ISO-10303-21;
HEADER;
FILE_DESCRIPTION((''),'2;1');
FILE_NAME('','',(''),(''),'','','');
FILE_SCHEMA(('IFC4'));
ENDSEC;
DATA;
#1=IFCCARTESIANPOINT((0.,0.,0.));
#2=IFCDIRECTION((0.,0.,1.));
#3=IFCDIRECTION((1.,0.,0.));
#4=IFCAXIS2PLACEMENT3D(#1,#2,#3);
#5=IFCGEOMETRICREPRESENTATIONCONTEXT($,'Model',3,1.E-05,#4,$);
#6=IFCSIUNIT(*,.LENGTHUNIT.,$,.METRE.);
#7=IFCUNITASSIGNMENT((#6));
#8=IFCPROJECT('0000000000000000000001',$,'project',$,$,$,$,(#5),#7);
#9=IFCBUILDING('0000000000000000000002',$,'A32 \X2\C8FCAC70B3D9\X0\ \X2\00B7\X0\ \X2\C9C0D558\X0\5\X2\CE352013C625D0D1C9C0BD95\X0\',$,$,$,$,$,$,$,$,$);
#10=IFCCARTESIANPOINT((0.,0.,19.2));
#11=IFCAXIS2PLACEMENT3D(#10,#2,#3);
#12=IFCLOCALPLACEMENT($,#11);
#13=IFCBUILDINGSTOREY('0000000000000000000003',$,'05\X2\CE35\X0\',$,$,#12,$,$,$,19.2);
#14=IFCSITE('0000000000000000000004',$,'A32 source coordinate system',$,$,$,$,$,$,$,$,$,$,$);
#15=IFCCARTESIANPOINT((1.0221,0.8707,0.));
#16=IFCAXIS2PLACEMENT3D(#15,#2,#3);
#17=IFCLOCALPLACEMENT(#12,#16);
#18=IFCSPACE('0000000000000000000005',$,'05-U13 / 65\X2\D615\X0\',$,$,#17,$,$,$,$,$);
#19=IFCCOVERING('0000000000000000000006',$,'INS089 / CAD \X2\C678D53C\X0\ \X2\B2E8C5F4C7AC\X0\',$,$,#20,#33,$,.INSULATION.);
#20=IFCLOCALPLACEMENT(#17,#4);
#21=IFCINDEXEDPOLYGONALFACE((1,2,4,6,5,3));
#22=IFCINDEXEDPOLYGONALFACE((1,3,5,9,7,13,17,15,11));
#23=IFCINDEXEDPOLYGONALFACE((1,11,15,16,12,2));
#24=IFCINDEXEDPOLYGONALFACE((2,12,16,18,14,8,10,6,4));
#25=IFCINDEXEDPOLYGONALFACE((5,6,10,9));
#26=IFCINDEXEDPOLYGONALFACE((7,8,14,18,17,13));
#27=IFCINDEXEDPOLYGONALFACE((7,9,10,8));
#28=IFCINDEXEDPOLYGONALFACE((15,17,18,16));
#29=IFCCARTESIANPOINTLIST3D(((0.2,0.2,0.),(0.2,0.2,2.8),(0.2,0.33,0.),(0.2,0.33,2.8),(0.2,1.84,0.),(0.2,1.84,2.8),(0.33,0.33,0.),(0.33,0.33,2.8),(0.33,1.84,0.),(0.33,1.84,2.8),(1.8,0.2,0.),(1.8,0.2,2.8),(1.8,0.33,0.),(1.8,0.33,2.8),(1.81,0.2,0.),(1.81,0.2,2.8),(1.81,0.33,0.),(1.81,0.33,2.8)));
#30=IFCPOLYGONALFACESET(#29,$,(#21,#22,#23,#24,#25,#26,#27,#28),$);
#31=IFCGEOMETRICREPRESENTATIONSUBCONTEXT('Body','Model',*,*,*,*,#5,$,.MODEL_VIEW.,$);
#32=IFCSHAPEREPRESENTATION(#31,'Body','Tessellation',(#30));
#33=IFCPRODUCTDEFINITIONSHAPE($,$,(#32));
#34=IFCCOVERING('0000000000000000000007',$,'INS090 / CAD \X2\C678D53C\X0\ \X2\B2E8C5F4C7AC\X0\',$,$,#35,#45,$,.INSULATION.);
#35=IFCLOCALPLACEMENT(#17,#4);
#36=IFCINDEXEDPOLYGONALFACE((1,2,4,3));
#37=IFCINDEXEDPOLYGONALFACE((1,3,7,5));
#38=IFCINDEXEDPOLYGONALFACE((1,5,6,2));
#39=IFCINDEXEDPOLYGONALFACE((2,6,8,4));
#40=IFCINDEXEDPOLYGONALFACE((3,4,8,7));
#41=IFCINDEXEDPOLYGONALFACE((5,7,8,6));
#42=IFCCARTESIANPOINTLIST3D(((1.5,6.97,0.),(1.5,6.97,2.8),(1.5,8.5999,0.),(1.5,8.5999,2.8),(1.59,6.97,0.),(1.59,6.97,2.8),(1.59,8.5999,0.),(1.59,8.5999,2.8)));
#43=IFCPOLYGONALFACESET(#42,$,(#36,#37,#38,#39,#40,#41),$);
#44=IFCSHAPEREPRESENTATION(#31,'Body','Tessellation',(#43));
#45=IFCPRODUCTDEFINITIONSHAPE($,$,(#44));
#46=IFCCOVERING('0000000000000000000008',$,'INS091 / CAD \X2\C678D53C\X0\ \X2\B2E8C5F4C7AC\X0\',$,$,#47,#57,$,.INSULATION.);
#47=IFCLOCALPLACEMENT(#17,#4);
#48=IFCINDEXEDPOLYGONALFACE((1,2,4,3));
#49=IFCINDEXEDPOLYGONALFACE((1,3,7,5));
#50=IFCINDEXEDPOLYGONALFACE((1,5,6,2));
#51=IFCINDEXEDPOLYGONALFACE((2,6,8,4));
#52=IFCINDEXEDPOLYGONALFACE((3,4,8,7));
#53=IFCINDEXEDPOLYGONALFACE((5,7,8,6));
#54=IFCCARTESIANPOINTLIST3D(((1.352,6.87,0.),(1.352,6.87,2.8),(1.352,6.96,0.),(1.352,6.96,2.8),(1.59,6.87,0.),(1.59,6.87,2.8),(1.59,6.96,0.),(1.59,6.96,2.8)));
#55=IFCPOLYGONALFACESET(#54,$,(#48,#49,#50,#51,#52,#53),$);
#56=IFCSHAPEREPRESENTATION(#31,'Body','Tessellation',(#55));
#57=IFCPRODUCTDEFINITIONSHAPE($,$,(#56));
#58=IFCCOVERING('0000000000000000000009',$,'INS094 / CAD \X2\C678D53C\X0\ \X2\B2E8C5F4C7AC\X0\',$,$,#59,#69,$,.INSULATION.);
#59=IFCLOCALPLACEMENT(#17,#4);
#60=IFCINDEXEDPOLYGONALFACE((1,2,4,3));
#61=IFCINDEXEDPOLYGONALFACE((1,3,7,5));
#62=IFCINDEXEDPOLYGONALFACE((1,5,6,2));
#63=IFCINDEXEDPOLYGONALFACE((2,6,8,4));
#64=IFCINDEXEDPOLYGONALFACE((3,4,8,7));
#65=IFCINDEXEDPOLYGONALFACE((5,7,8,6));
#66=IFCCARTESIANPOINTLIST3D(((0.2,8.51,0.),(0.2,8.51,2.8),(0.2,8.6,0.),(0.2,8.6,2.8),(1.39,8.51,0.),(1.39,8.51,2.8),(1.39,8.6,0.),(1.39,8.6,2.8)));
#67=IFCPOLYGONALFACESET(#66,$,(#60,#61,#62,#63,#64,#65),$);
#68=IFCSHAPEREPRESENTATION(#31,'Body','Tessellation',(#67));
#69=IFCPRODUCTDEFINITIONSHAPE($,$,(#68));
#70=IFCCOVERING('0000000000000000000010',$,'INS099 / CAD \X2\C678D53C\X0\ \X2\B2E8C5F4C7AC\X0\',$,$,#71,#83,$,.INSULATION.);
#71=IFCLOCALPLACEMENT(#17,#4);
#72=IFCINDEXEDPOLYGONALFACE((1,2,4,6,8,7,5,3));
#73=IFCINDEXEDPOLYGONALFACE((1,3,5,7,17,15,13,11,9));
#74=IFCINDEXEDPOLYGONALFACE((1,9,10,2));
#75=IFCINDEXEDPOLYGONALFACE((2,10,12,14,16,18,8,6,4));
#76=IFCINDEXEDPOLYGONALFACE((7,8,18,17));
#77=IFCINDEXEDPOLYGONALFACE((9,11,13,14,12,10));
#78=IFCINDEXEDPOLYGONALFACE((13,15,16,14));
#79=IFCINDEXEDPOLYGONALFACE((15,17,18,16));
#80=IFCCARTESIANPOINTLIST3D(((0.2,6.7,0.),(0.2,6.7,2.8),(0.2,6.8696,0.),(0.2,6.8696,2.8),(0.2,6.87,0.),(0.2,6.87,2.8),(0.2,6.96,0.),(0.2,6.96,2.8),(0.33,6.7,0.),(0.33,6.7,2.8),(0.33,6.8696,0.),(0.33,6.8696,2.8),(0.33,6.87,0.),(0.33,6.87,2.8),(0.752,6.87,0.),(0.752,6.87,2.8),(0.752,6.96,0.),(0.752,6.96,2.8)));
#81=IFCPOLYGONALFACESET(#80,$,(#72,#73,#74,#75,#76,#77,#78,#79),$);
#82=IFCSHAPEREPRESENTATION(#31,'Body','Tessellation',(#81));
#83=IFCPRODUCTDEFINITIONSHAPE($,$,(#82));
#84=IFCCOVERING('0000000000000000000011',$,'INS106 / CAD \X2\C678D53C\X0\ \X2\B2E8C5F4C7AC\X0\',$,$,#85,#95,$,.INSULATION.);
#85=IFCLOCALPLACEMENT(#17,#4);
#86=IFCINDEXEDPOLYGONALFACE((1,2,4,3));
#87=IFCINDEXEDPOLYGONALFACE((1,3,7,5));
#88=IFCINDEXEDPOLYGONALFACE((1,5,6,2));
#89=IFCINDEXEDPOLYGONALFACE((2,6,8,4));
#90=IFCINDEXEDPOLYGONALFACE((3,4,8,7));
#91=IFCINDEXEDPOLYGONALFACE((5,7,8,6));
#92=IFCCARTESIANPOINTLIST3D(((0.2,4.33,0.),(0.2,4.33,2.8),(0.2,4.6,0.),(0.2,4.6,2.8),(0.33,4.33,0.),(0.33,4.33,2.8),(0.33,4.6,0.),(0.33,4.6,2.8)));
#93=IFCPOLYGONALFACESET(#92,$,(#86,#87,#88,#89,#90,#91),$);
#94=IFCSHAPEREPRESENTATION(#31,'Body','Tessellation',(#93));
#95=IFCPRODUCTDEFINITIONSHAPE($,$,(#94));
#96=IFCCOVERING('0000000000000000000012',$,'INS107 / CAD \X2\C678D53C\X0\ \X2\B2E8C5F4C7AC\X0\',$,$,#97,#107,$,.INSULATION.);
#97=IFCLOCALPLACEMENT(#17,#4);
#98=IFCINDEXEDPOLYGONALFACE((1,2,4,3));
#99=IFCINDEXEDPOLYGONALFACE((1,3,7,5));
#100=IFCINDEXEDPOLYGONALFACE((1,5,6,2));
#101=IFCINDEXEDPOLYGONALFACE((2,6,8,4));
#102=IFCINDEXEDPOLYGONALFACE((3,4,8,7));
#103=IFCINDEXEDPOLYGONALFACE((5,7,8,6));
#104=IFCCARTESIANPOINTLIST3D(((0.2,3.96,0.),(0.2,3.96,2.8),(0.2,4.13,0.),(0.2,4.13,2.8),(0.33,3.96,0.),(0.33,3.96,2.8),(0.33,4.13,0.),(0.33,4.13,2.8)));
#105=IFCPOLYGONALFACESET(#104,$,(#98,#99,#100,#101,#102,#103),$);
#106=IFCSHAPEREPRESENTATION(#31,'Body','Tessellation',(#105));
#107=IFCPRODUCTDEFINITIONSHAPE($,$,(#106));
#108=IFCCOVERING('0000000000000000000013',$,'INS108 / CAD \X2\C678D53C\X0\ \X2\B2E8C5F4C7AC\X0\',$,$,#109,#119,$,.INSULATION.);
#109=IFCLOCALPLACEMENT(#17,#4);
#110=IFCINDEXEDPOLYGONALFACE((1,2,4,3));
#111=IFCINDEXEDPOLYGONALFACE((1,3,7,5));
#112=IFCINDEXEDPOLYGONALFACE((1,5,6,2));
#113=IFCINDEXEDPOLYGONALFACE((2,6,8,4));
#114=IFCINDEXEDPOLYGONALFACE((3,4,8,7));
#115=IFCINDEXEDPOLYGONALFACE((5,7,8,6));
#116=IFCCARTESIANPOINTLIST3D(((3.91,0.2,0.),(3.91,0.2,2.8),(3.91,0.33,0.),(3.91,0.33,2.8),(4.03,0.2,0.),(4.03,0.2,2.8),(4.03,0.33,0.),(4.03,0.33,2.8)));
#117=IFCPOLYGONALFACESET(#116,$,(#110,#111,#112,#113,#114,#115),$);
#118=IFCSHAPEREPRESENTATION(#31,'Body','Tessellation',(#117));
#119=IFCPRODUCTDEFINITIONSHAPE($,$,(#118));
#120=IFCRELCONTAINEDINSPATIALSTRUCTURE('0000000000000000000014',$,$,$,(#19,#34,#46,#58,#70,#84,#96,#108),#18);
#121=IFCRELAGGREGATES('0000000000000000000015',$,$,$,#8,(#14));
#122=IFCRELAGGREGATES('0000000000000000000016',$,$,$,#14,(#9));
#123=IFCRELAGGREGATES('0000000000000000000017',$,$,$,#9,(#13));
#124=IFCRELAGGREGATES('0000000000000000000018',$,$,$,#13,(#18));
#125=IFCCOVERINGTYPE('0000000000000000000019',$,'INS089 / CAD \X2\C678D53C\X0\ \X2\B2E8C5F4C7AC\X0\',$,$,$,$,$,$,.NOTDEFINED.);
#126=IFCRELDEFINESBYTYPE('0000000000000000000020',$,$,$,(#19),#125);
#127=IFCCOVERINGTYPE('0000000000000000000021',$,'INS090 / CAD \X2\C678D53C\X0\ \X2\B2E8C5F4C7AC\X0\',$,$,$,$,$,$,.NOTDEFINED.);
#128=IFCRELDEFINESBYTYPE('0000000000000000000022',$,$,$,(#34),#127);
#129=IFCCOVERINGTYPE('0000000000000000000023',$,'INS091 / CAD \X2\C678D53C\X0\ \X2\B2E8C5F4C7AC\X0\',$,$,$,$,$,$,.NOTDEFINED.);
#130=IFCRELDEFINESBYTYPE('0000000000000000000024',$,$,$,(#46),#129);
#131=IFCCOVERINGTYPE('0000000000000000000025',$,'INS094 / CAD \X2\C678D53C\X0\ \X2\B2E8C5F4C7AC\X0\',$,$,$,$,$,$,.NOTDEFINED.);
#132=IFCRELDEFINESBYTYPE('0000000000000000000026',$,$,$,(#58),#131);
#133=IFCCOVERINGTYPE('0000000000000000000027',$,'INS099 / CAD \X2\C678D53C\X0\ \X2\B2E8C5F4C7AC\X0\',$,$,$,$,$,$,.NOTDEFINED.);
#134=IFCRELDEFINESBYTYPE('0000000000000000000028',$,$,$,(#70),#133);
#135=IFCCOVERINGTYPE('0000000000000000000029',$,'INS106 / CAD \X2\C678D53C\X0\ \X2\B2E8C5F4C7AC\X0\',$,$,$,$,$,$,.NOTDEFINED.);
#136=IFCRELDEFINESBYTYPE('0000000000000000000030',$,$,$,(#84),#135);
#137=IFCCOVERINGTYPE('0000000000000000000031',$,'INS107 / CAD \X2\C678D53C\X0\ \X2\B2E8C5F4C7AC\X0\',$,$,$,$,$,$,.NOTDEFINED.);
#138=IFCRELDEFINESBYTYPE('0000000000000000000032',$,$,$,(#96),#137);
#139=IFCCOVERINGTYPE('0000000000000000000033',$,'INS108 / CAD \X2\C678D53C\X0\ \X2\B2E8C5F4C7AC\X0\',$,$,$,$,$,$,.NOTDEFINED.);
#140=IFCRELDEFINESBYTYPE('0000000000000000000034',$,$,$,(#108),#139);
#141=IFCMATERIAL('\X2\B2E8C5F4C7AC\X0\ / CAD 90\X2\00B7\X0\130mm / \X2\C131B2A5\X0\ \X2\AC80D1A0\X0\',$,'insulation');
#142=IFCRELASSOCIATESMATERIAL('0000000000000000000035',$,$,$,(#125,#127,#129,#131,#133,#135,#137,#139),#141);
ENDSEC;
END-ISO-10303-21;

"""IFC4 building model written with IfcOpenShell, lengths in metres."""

from ifc_helpers import new_model, si_unit, frame, origin, origin_with_axes, place, context, subcontext, project, spatial, polyline, outline, extrude, source, transform, mapped, material, type_object, type_shapes, element, save


model = new_model("IFC4")

# Units and contexts
model_context = context("Model", 3, precision=1e-05, world=origin_with_axes())
body_context = subcontext(model_context, "Body", "Model", "MODEL_VIEW")
ifc_project = project(units=[si_unit("LENGTHUNIT", "METRE")], contexts=[model_context])

# Site, building, storey
site = spatial("IfcSite", under=ifc_project, Name="A32 source coordinate system")
building = spatial("IfcBuilding", under=site, Name="A32 주거동 · 지하5층–옥탑지붕")
storey_placement = place(None, frame((0.0, 0.0, 19.2), z_axis=(0.0, 0.0, 1.0), x_axis=(1.0, 0.0, 0.0)))
storey = spatial("IfcBuildingStorey", under=building, at=storey_placement, Name="05층", Elevation=19.2)

# Shared definitions
space_placement = place(storey_placement, frame((1.0221, 0.8707, 0.0), z_axis=(0.0, 0.0, 1.0), x_axis=(1.0, 0.0, 0.0)))
space = spatial("IfcSpace", under=storey, at=space_placement, Name="05-U13 / 65형")

# Coverings
ifc_material = material(Name="단열재 / CAD 90·130mm / 성능 검토", Category="insulation")
covering_type_1 = type_object("IfcCoveringType", Name="INS089 / CAD 외피 단열재", PredefinedType="NOTDEFINED", material=ifc_material)
shared_shape_1 = source(origin(), body_context, "Body", "SweptSolid", [
    extrude(outline(polyline([(0.2, 0.33), (0.2, 1.84), (0.33, 1.84), (0.33, 0.33), (1.8, 0.33), (1.81, 0.33), (1.81, 0.2), (1.8, 0.2), (0.2, 0.2), (0.2, 0.33)])), origin(), (0.0, 0.0, 1.0), 2.8),
])
type_shapes(covering_type_1, [shared_shape_1])
covering_1_placement = place(space_placement, origin_with_axes())
element("IfcCovering", 1, at=covering_1_placement, inside=space, type_object=covering_type_1, Name="INS089 / CAD 외피 단열재", PredefinedType="INSULATION", context=body_context, shape_type="MappedRepresentation", body=[
    mapped(shared_shape_1, transform((0.0, 0.0, 0.0), scale=1.0)),
])
covering_type_2 = type_object("IfcCoveringType", Name="INS090 / CAD 외피 단열재", PredefinedType="NOTDEFINED", material=ifc_material)
shared_shape_2 = source(origin(), body_context, "Body", "SweptSolid", [
    extrude(outline(polyline([(1.59, 6.97), (1.5, 6.97), (1.5, 8.5999), (1.59, 8.5999), (1.59, 6.97)])), origin(), (0.0, 0.0, 1.0), 2.8),
])
type_shapes(covering_type_2, [shared_shape_2])
covering_2_placement = place(space_placement, origin_with_axes())
element("IfcCovering", 2, at=covering_2_placement, inside=space, type_object=covering_type_2, Name="INS090 / CAD 외피 단열재", PredefinedType="INSULATION", context=body_context, shape_type="MappedRepresentation", body=[
    mapped(shared_shape_2, transform((0.0, 0.0, 0.0), scale=1.0)),
])
covering_type_3 = type_object("IfcCoveringType", Name="INS091 / CAD 외피 단열재", PredefinedType="NOTDEFINED", material=ifc_material)
shared_shape_3 = source(origin(), body_context, "Body", "SweptSolid", [
    extrude(outline(polyline([(1.59, 6.96), (1.59, 6.87), (1.352, 6.87), (1.352, 6.96), (1.59, 6.96)])), origin(), (0.0, 0.0, 1.0), 2.8),
])
type_shapes(covering_type_3, [shared_shape_3])
covering_3_placement = place(space_placement, origin_with_axes())
element("IfcCovering", 3, at=covering_3_placement, inside=space, type_object=covering_type_3, Name="INS091 / CAD 외피 단열재", PredefinedType="INSULATION", context=body_context, shape_type="MappedRepresentation", body=[
    mapped(shared_shape_3, transform((0.0, 0.0, 0.0), scale=1.0)),
])
covering_type_4 = type_object("IfcCoveringType", Name="INS094 / CAD 외피 단열재", PredefinedType="NOTDEFINED", material=ifc_material)
shared_shape_4 = source(origin(), body_context, "Body", "SweptSolid", [
    extrude(outline(polyline([(1.39, 8.51), (0.2, 8.51), (0.2, 8.6), (1.39, 8.6), (1.39, 8.51)])), origin(), (0.0, 0.0, 1.0), 2.8),
])
type_shapes(covering_type_4, [shared_shape_4])
covering_4_placement = place(space_placement, origin_with_axes())
element("IfcCovering", 4, at=covering_4_placement, inside=space, type_object=covering_type_4, Name="INS094 / CAD 외피 단열재", PredefinedType="INSULATION", context=body_context, shape_type="MappedRepresentation", body=[
    mapped(shared_shape_4, transform((0.0, 0.0, 0.0), scale=1.0)),
])
covering_type_5 = type_object("IfcCoveringType", Name="INS099 / CAD 외피 단열재", PredefinedType="NOTDEFINED", material=ifc_material)
shared_shape_5 = source(origin(), body_context, "Body", "SweptSolid", [
    extrude(outline(polyline([(0.2, 6.8696), (0.2, 6.87), (0.2, 6.96), (0.752, 6.96), (0.752, 6.87), (0.33, 6.87), (0.33, 6.8696), (0.33, 6.7), (0.2, 6.7), (0.2, 6.8696)])), origin(), (0.0, 0.0, 1.0), 2.8),
])
type_shapes(covering_type_5, [shared_shape_5])
covering_5_placement = place(space_placement, origin_with_axes())
element("IfcCovering", 5, at=covering_5_placement, inside=space, type_object=covering_type_5, Name="INS099 / CAD 외피 단열재", PredefinedType="INSULATION", context=body_context, shape_type="MappedRepresentation", body=[
    mapped(shared_shape_5, transform((0.0, 0.0, 0.0), scale=1.0)),
])
covering_type_6 = type_object("IfcCoveringType", Name="INS106 / CAD 외피 단열재", PredefinedType="NOTDEFINED", material=ifc_material)
shared_shape_6 = source(origin(), body_context, "Body", "SweptSolid", [
    extrude(outline(polyline([(0.33, 4.6), (0.33, 4.33), (0.2, 4.33), (0.2, 4.6), (0.33, 4.6)])), origin(), (0.0, 0.0, 1.0), 2.8),
])
type_shapes(covering_type_6, [shared_shape_6])
covering_6_placement = place(space_placement, origin_with_axes())
element("IfcCovering", 6, at=covering_6_placement, inside=space, type_object=covering_type_6, Name="INS106 / CAD 외피 단열재", PredefinedType="INSULATION", context=body_context, shape_type="MappedRepresentation", body=[
    mapped(shared_shape_6, transform((0.0, 0.0, 0.0), scale=1.0)),
])
covering_type_7 = type_object("IfcCoveringType", Name="INS107 / CAD 외피 단열재", PredefinedType="NOTDEFINED", material=ifc_material)
shared_shape_7 = source(origin(), body_context, "Body", "SweptSolid", [
    extrude(outline(polyline([(0.33, 3.96), (0.2, 3.96), (0.2, 4.13), (0.33, 4.13), (0.33, 3.96)])), origin(), (0.0, 0.0, 1.0), 2.8),
])
type_shapes(covering_type_7, [shared_shape_7])
covering_7_placement = place(space_placement, origin_with_axes())
element("IfcCovering", 7, at=covering_7_placement, inside=space, type_object=covering_type_7, Name="INS107 / CAD 외피 단열재", PredefinedType="INSULATION", context=body_context, shape_type="MappedRepresentation", body=[
    mapped(shared_shape_7, transform((0.0, 0.0, 0.0), scale=1.0)),
])
covering_type_8 = type_object("IfcCoveringType", Name="INS108 / CAD 외피 단열재", PredefinedType="NOTDEFINED", material=ifc_material)
shared_shape_8 = source(origin(), body_context, "Body", "SweptSolid", [
    extrude(outline(polyline([(4.03, 0.2), (3.91, 0.2), (3.91, 0.33), (4.03, 0.33), (4.03, 0.2)])), origin(), (0.0, 0.0, 1.0), 2.8),
])
type_shapes(covering_type_8, [shared_shape_8])
covering_8_placement = place(space_placement, origin_with_axes())
element("IfcCovering", 8, at=covering_8_placement, inside=space, type_object=covering_type_8, Name="INS108 / CAD 외피 단열재", PredefinedType="INSULATION", context=body_context, shape_type="MappedRepresentation", body=[
    mapped(shared_shape_8, transform((0.0, 0.0, 0.0), scale=1.0)),
])

save(model, "model.ifc")
